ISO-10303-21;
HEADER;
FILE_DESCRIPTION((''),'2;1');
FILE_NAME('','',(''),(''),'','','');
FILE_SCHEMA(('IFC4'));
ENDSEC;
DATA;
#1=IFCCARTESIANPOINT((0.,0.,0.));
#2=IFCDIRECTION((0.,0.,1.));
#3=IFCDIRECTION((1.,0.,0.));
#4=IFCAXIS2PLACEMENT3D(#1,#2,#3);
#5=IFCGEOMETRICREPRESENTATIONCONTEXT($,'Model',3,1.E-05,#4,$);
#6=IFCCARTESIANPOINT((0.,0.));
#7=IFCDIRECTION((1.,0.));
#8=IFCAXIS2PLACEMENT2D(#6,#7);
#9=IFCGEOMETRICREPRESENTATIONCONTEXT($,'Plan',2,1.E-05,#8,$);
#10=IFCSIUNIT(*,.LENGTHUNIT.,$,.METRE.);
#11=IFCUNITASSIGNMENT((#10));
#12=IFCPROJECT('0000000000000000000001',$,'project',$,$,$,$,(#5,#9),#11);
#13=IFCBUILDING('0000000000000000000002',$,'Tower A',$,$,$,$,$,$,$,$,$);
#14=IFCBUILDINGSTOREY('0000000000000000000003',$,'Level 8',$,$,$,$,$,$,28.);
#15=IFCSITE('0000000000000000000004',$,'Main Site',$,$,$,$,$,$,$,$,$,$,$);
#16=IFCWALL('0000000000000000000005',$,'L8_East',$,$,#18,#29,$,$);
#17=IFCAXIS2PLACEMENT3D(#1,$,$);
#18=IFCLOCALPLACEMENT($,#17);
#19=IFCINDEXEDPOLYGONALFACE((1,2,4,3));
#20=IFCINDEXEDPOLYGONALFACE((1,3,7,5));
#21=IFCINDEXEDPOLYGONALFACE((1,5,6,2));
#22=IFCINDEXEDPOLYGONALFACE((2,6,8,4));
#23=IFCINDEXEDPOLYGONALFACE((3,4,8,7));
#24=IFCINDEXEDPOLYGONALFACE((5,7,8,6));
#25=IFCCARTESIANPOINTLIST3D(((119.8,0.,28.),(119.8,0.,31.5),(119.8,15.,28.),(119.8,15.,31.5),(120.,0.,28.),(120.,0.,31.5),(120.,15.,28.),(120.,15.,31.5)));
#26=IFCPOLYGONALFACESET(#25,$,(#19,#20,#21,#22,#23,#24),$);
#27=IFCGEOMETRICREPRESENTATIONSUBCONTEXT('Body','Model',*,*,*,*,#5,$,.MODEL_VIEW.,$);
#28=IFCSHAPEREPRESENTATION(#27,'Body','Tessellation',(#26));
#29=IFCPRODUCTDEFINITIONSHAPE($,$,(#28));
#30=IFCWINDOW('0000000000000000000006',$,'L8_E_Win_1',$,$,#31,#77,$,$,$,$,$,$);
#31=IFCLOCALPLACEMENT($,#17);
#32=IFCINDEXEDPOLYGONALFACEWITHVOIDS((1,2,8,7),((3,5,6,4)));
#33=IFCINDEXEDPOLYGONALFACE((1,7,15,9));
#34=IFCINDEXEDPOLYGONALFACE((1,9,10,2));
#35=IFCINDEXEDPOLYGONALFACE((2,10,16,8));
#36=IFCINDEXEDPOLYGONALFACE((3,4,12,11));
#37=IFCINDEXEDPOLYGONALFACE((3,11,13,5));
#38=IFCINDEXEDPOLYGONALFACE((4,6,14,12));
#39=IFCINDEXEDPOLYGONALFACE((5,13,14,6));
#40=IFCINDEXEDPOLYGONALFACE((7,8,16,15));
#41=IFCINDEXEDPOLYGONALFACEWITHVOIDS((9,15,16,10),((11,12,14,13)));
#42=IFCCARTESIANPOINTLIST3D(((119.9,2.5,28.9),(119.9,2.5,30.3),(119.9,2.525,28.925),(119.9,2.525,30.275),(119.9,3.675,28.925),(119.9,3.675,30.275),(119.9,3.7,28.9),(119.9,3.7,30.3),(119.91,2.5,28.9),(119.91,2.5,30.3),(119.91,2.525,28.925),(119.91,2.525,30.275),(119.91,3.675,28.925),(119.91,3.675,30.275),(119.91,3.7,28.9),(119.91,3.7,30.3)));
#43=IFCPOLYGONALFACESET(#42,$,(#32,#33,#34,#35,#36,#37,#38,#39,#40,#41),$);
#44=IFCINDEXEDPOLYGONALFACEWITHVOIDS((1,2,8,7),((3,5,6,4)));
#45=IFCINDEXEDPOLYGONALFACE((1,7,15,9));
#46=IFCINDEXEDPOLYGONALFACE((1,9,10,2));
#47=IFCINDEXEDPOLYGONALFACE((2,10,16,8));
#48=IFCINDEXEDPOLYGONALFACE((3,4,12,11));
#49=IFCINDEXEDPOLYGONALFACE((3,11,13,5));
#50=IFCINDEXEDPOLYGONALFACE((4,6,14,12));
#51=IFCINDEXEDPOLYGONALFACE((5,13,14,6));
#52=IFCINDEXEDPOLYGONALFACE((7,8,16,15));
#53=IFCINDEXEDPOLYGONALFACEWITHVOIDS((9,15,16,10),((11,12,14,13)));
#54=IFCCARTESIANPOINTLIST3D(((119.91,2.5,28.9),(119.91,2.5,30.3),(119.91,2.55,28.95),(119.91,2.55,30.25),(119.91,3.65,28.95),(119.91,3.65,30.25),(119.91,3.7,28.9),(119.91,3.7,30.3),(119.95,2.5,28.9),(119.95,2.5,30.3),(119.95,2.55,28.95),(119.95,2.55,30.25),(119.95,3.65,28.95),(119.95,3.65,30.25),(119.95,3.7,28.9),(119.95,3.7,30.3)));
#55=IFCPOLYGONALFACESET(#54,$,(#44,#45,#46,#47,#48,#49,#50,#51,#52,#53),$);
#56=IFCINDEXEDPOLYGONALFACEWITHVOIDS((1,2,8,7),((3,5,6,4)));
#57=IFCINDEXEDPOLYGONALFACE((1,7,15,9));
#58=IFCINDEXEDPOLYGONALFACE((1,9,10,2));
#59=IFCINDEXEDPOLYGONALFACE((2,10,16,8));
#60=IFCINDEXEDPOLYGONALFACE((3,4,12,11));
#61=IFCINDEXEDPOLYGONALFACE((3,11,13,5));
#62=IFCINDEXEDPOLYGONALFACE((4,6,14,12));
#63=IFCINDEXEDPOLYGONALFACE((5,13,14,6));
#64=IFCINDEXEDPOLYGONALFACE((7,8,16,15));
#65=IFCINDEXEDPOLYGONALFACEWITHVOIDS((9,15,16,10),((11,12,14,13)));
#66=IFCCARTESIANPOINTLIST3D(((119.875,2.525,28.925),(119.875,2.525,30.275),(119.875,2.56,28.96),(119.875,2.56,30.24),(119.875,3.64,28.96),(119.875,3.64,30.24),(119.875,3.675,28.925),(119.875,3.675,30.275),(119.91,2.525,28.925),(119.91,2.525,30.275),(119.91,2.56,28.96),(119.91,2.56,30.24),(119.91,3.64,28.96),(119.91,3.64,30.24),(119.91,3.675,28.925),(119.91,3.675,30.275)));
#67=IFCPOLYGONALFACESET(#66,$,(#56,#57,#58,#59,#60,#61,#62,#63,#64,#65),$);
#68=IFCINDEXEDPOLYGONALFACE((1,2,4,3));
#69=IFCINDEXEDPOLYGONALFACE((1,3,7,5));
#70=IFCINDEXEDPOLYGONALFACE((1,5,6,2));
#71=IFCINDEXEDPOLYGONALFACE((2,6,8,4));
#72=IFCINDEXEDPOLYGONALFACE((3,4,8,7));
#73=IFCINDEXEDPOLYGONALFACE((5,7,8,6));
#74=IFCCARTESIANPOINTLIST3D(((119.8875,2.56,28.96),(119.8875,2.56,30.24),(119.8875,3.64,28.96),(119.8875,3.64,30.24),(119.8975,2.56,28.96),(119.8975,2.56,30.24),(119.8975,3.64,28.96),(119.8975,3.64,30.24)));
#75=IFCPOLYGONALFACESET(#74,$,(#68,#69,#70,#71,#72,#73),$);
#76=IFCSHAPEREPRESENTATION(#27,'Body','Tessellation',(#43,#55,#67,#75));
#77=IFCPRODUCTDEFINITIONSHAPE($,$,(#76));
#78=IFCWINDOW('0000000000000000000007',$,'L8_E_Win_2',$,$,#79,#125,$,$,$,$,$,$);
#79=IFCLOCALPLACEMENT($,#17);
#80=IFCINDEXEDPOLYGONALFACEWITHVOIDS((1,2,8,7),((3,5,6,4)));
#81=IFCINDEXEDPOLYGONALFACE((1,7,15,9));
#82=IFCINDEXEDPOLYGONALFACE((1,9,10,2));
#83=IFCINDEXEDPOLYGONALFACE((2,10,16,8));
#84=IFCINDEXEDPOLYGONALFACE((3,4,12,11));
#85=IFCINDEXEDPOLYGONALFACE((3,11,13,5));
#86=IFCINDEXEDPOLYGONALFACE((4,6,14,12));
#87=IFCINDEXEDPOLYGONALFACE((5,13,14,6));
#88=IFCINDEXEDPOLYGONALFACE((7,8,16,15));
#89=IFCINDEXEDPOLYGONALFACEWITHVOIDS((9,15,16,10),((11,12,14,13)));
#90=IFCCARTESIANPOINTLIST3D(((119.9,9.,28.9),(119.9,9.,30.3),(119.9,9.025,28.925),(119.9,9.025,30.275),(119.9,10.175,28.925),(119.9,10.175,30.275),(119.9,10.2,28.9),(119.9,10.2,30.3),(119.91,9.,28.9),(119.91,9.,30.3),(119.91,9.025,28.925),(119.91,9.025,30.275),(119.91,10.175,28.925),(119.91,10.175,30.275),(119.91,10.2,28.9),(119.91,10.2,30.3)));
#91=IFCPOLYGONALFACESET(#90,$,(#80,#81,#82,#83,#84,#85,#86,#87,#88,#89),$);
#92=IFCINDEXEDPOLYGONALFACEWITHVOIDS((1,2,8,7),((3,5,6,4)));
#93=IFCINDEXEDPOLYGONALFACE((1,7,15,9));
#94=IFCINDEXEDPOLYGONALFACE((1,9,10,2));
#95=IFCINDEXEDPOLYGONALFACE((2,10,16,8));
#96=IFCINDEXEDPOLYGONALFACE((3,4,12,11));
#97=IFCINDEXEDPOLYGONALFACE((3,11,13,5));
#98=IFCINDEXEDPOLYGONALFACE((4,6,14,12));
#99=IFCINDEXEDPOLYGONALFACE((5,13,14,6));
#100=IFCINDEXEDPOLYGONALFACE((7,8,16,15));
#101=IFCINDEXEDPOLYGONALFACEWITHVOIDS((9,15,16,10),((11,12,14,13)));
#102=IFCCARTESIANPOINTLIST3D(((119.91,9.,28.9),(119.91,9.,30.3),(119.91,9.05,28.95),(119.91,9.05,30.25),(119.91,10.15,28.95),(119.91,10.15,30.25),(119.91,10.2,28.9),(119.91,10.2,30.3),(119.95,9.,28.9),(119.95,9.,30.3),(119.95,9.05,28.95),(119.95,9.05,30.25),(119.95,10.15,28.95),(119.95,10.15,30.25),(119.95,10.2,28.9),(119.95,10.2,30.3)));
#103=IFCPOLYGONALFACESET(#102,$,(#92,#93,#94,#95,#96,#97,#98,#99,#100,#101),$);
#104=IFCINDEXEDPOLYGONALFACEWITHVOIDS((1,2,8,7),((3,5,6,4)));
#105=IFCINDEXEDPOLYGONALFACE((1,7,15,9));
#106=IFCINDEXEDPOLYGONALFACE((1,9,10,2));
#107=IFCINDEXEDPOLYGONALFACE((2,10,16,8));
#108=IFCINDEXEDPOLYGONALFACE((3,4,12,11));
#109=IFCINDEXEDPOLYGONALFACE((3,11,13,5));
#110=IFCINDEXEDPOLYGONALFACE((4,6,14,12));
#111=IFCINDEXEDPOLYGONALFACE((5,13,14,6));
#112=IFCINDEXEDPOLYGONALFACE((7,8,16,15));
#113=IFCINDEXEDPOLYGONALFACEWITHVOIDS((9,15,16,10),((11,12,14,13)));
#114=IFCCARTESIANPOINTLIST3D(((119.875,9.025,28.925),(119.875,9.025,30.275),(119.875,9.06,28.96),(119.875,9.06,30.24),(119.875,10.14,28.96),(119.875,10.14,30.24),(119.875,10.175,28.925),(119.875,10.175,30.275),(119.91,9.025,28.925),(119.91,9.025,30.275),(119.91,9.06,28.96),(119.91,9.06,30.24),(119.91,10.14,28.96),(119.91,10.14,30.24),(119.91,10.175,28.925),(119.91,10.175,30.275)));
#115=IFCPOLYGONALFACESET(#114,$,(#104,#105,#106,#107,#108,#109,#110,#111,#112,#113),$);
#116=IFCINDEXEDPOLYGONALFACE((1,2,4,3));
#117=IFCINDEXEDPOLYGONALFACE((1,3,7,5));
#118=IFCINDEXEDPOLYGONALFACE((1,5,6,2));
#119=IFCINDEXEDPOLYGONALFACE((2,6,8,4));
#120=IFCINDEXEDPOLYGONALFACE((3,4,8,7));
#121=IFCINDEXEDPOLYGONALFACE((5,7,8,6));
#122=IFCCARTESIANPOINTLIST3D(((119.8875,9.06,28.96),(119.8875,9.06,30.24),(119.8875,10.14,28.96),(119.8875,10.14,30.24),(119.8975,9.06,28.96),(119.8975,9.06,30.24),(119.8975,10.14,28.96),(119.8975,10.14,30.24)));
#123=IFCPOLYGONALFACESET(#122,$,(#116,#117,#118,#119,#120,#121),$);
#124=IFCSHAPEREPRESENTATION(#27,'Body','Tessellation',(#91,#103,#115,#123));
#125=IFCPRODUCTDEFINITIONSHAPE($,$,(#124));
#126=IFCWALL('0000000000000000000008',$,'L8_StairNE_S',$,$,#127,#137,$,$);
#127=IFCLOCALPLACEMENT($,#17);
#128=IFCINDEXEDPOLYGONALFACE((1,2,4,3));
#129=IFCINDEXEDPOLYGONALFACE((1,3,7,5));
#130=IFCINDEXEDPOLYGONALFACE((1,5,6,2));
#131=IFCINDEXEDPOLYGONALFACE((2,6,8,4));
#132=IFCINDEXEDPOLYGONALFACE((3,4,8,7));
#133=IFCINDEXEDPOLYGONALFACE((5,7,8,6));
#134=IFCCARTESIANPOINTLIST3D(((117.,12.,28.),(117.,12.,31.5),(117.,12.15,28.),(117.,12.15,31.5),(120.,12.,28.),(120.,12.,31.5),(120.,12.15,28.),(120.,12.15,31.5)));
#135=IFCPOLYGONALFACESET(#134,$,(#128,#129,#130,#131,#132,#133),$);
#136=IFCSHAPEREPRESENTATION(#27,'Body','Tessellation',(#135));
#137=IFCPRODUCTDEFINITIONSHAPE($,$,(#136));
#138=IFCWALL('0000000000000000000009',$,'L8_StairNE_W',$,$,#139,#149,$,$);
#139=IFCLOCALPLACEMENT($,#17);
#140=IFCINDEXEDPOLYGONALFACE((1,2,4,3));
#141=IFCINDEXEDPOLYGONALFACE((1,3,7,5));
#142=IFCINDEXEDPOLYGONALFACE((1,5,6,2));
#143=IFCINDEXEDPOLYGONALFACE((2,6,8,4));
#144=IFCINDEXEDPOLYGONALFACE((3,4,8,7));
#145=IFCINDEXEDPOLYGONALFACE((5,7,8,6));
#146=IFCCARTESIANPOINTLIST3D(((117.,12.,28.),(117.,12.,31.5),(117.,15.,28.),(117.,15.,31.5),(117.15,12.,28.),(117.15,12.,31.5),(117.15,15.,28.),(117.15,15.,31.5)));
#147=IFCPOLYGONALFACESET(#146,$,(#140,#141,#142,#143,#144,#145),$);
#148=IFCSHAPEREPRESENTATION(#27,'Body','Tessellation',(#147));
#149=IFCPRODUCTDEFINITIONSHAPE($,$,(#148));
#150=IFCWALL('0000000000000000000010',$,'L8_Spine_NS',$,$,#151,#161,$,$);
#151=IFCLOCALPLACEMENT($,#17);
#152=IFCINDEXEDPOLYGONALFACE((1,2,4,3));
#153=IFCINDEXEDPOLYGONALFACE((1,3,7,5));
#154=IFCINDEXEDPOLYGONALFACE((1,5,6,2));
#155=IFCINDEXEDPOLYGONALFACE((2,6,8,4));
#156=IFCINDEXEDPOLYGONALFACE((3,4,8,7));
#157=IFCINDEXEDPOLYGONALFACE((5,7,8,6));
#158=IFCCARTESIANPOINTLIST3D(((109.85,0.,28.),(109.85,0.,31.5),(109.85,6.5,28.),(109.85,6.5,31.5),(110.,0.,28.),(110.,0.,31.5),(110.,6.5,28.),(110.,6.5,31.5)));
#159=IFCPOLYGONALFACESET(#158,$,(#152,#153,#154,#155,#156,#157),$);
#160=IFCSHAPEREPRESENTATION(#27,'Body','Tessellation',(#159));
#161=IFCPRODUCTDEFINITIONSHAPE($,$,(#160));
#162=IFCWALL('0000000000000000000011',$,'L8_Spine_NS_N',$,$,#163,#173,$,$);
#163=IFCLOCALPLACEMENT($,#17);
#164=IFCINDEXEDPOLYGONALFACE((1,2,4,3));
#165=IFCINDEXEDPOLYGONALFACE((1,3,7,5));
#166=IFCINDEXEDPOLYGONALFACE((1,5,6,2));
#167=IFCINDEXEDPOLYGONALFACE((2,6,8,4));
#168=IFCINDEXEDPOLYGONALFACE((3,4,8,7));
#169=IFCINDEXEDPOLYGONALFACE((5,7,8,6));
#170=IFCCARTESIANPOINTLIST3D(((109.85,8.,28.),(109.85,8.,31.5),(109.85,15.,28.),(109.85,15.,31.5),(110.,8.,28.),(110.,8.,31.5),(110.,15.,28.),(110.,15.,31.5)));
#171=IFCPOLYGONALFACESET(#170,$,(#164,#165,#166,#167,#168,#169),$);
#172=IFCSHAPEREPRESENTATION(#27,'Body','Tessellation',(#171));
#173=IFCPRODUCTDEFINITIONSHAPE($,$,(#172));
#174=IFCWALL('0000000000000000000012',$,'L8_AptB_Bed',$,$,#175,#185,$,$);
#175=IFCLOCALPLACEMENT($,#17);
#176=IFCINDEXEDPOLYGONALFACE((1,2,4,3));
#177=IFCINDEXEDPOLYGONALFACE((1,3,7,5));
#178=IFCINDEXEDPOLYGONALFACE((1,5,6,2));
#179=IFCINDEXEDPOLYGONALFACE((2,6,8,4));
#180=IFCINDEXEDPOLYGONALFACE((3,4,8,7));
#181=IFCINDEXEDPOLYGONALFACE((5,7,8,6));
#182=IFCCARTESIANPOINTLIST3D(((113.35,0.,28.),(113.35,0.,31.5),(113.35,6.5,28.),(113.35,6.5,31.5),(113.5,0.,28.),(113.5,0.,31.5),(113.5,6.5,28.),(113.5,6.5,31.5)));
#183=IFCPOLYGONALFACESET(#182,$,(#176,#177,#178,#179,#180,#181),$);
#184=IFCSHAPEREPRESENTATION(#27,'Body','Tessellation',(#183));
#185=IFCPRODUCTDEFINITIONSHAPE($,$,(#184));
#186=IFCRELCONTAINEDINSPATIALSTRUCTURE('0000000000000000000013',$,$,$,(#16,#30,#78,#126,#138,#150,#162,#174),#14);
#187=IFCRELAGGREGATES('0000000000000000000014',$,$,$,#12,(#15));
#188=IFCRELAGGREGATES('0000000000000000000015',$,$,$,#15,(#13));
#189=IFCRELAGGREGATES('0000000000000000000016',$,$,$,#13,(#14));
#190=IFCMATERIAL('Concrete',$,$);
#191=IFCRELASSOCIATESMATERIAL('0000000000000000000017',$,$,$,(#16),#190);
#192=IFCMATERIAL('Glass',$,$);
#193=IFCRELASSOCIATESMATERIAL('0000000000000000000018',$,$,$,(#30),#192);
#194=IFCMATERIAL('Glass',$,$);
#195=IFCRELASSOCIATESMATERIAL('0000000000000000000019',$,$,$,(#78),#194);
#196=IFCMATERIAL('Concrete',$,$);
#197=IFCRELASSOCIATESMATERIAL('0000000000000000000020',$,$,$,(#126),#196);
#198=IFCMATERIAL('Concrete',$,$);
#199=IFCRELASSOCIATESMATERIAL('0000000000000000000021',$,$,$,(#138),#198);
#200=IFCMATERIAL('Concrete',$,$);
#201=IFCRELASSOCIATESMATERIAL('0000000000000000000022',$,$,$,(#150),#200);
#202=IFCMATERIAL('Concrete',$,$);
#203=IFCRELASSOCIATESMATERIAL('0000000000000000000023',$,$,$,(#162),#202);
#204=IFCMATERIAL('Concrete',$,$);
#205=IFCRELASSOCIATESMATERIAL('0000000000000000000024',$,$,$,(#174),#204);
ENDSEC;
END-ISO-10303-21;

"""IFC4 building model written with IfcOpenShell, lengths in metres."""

from ifc_helpers import new_model, si_unit, frame, origin_with_axes, origin_2d_with_axis, place, context, subcontext, project, spatial, line, indexed_curve, outline, extrude, material, element, fill, save


model = new_model("IFC4")

# Units and contexts
model_context = context("Model", 3, precision=1e-05, world=origin_with_axes())
plan_context = context("Plan", 2, precision=1e-05, world=origin_2d_with_axis())
body_context = subcontext(model_context, "Body", "Model", "MODEL_VIEW")
ifc_project = project(units=[si_unit("LENGTHUNIT", "METRE")], contexts=[model_context, plan_context])

# Site, building, storey
site = spatial("IfcSite", under=ifc_project, Name="Main Site")
building = spatial("IfcBuilding", under=site, Name="Tower A")
storey = spatial("IfcBuildingStorey", under=building, Name="Level 8", Elevation=28.0)

# Wall, openings, windows
ifc_material_1 = material(Name="Concrete")
wall_1_placement = place(None, frame((120.0, 0.0, 28.0), z_axis=(0.0, 0.0, 1.0), x_axis=(0.0, 1.0, 0.0)))
wall_1 = element("IfcWall", 1, at=wall_1_placement, inside=storey, material=ifc_material_1, Name="L8_East", context=body_context, shape_type="SweptSolid", body=[
    extrude(outline(indexed_curve([(0.0, 0.0), (0.0, 0.2), (15.0, 0.2), (15.0, 0.0), (0.0, 0.0)], self_intersect=False)), origin_with_axes(), (0.0, 0.0, 1.0), 3.5),
])
opening_1_placement = place(wall_1_placement, frame((2.5, 0.0, 0.9), z_axis=(0.0, 0.0, 1.0), x_axis=(0.0, -1.0, 0.0)))
opening_1 = element("IfcOpeningElement", 2, at=opening_1_placement, cuts=wall_1, context=body_context, shape_type="SweptSolid", body=[
    extrude(outline(indexed_curve([(0.0, 0.0), (0.0, 0.25), (1.2, 0.25), (1.2, 0.0), (0.0, 0.0)], self_intersect=False)), origin_with_axes(), (0.0, 0.0, 1.0), 1.4),
])
opening_2_placement = place(wall_1_placement, frame((9.0, 0.0, 0.9), z_axis=(0.0, 0.0, 1.0), x_axis=(0.0, -1.0, 0.0)))
opening_2 = element("IfcOpeningElement", 3, at=opening_2_placement, cuts=wall_1, context=body_context, shape_type="SweptSolid", body=[
    extrude(outline(indexed_curve([(0.0, 0.0), (0.0, 0.25), (1.2, 0.25), (1.2, 0.0), (0.0, 0.0)], self_intersect=False)), origin_with_axes(), (0.0, 0.0, 1.0), 1.4),
])
ifc_material_2 = material(Name="Glass")
window_1_placement = place(None, frame((120.0, 2.5, 28.9), z_axis=(0.0, 0.0, 1.0), x_axis=(0.0, 1.0, 0.0)))
window_1 = element("IfcWindow", 4, at=window_1_placement, inside=storey, material=ifc_material_2, Name="L8_E_Win_1", context=body_context, shape_type="SweptSolid", body=[
    extrude(outline(indexed_curve([(0.0, 0.0), (1.2, 0.0), (1.2, 1.4), (0.0, 1.4)], segments=[line(1, 2, 3, 4, 1)]), holes=[indexed_curve([(0.025, 0.025), (1.175, 0.025), (1.175, 1.375), (0.025, 1.375)], segments=[line(1, 2, 3, 4, 1)])]), frame((0.0, 0.09, 0.0), z_axis=(0.0, -1.0, 0.0), x_axis=(1.0, 0.0, 0.0)), (0.0, 0.0, -1.0), 0.01),
    extrude(outline(indexed_curve([(0.0, 0.0), (1.2, 0.0), (1.2, 1.4), (0.0, 1.4)], segments=[line(1, 2, 3, 4, 1)]), holes=[indexed_curve([(0.05, 0.05), (1.15, 0.05), (1.15, 1.35), (0.05, 1.35)], segments=[line(1, 2, 3, 4, 1)])]), frame((0.0, 0.05, 0.0), z_axis=(0.0, -1.0, 0.0), x_axis=(1.0, 0.0, 0.0)), (0.0, 0.0, -1.0), 0.04),
    extrude(outline(indexed_curve([(0.0, 0.0), (1.15, 0.0), (1.15, 1.35), (0.0, 1.35)], segments=[line(1, 2, 3, 4, 1)]), holes=[indexed_curve([(0.035, 0.035), (1.115, 0.035), (1.115, 1.315), (0.035, 1.315)], segments=[line(1, 2, 3, 4, 1)])]), frame((0.025, 0.09, 0.025), z_axis=(0.0, -1.0, 0.0), x_axis=(1.0, 0.0, 0.0)), (0.0, 0.0, -1.0), 0.035),
    extrude(outline(indexed_curve([(0.035, 0.035), (1.115, 0.035), (1.115, 1.315), (0.035, 1.315)], segments=[line(1, 2, 3, 4, 1)])), frame((0.025, 0.1025, 0.025), z_axis=(0.0, -1.0, 0.0), x_axis=(1.0, 0.0, 0.0)), (0.0, 0.0, -1.0), 0.01),
])
fill(opening_1, window_1)
ifc_material_3 = material(Name="Glass")
window_2_placement = place(None, frame((120.0, 9.0, 28.9), z_axis=(0.0, 0.0, 1.0), x_axis=(0.0, 1.0, 0.0)))
window_2 = element("IfcWindow", 5, at=window_2_placement, inside=storey, material=ifc_material_3, Name="L8_E_Win_2", context=body_context, shape_type="SweptSolid", body=[
    extrude(outline(indexed_curve([(0.0, 0.0), (1.2, 0.0), (1.2, 1.4), (0.0, 1.4)], segments=[line(1, 2, 3, 4, 1)]), holes=[indexed_curve([(0.025, 0.025), (1.175, 0.025), (1.175, 1.375), (0.025, 1.375)], segments=[line(1, 2, 3, 4, 1)])]), frame((0.0, 0.09, 0.0), z_axis=(0.0, -1.0, 0.0), x_axis=(1.0, 0.0, 0.0)), (0.0, 0.0, -1.0), 0.01),
    extrude(outline(indexed_curve([(0.0, 0.0), (1.2, 0.0), (1.2, 1.4), (0.0, 1.4)], segments=[line(1, 2, 3, 4, 1)]), holes=[indexed_curve([(0.05, 0.05), (1.15, 0.05), (1.15, 1.35), (0.05, 1.35)], segments=[line(1, 2, 3, 4, 1)])]), frame((0.0, 0.05, 0.0), z_axis=(0.0, -1.0, 0.0), x_axis=(1.0, 0.0, 0.0)), (0.0, 0.0, -1.0), 0.04),
    extrude(outline(indexed_curve([(0.0, 0.0), (1.15, 0.0), (1.15, 1.35), (0.0, 1.35)], segments=[line(1, 2, 3, 4, 1)]), holes=[indexed_curve([(0.035, 0.035), (1.115, 0.035), (1.115, 1.315), (0.035, 1.315)], segments=[line(1, 2, 3, 4, 1)])]), frame((0.025, 0.09, 0.025), z_axis=(0.0, -1.0, 0.0), x_axis=(1.0, 0.0, 0.0)), (0.0, 0.0, -1.0), 0.035),
    extrude(outline(indexed_curve([(0.035, 0.035), (1.115, 0.035), (1.115, 1.315), (0.035, 1.315)], segments=[line(1, 2, 3, 4, 1)])), frame((0.025, 0.1025, 0.025), z_axis=(0.0, -1.0, 0.0), x_axis=(1.0, 0.0, 0.0)), (0.0, 0.0, -1.0), 0.01),
])
fill(opening_2, window_2)

# Walls
ifc_material_4 = material(Name="Concrete")
wall_2_placement = place(None, frame((117.0, 12.0, 28.0), z_axis=(0.0, 0.0, 1.0), x_axis=(1.0, 0.0, 0.0)))
element("IfcWall", 6, at=wall_2_placement, inside=storey, material=ifc_material_4, Name="L8_StairNE_S", context=body_context, shape_type="SweptSolid", body=[
    extrude(outline(indexed_curve([(0.0, 0.0), (0.0, 0.15), (3.0, 0.15), (3.0, 0.0), (0.0, 0.0)], self_intersect=False)), origin_with_axes(), (0.0, 0.0, 1.0), 3.5),
])
ifc_material_5 = material(Name="Concrete")
wall_3_placement = place(None, frame((117.0, 15.0, 28.0), z_axis=(0.0, 0.0, 1.0), x_axis=(0.0, -1.0, 0.0)))
element("IfcWall", 7, at=wall_3_placement, inside=storey, material=ifc_material_5, Name="L8_StairNE_W", context=body_context, shape_type="SweptSolid", body=[
    extrude(outline(indexed_curve([(0.0, 0.0), (0.0, 0.15), (3.0, 0.15), (3.0, 0.0), (0.0, 0.0)], self_intersect=False)), origin_with_axes(), (0.0, 0.0, 1.0), 3.5),
])
ifc_material_6 = material(Name="Concrete")
wall_4_placement = place(None, frame((110.0, 0.0, 28.0), z_axis=(0.0, 0.0, 1.0), x_axis=(0.0, 1.0, 0.0)))
element("IfcWall", 8, at=wall_4_placement, inside=storey, material=ifc_material_6, Name="L8_Spine_NS", context=body_context, shape_type="SweptSolid", body=[
    extrude(outline(indexed_curve([(0.0, 0.0), (0.0, 0.15), (6.5, 0.15), (6.5, 0.0), (0.0, 0.0)], self_intersect=False)), origin_with_axes(), (0.0, 0.0, 1.0), 3.5),
])
ifc_material_7 = material(Name="Concrete")
wall_5_placement = place(None, frame((110.0, 8.0, 28.0), z_axis=(0.0, 0.0, 1.0), x_axis=(0.0, 1.0, 0.0)))
element("IfcWall", 9, at=wall_5_placement, inside=storey, material=ifc_material_7, Name="L8_Spine_NS_N", context=body_context, shape_type="SweptSolid", body=[
    extrude(outline(indexed_curve([(0.0, 0.0), (0.0, 0.15), (7.0, 0.15), (7.0, 0.0), (0.0, 0.0)], self_intersect=False)), origin_with_axes(), (0.0, 0.0, 1.0), 3.5),
])
ifc_material_8 = material(Name="Concrete")
wall_6_placement = place(None, frame((113.5, 0.0, 28.0), z_axis=(0.0, 0.0, 1.0), x_axis=(0.0, 1.0, 0.0)))
element("IfcWall", 10, at=wall_6_placement, inside=storey, material=ifc_material_8, Name="L8_AptB_Bed", context=body_context, shape_type="SweptSolid", body=[
    extrude(outline(indexed_curve([(0.0, 0.0), (0.0, 0.15), (6.5, 0.15), (6.5, 0.0), (0.0, 0.0)], self_intersect=False)), origin_with_axes(), (0.0, 0.0, 1.0), 3.5),
])

save(model, "model.ifc")
